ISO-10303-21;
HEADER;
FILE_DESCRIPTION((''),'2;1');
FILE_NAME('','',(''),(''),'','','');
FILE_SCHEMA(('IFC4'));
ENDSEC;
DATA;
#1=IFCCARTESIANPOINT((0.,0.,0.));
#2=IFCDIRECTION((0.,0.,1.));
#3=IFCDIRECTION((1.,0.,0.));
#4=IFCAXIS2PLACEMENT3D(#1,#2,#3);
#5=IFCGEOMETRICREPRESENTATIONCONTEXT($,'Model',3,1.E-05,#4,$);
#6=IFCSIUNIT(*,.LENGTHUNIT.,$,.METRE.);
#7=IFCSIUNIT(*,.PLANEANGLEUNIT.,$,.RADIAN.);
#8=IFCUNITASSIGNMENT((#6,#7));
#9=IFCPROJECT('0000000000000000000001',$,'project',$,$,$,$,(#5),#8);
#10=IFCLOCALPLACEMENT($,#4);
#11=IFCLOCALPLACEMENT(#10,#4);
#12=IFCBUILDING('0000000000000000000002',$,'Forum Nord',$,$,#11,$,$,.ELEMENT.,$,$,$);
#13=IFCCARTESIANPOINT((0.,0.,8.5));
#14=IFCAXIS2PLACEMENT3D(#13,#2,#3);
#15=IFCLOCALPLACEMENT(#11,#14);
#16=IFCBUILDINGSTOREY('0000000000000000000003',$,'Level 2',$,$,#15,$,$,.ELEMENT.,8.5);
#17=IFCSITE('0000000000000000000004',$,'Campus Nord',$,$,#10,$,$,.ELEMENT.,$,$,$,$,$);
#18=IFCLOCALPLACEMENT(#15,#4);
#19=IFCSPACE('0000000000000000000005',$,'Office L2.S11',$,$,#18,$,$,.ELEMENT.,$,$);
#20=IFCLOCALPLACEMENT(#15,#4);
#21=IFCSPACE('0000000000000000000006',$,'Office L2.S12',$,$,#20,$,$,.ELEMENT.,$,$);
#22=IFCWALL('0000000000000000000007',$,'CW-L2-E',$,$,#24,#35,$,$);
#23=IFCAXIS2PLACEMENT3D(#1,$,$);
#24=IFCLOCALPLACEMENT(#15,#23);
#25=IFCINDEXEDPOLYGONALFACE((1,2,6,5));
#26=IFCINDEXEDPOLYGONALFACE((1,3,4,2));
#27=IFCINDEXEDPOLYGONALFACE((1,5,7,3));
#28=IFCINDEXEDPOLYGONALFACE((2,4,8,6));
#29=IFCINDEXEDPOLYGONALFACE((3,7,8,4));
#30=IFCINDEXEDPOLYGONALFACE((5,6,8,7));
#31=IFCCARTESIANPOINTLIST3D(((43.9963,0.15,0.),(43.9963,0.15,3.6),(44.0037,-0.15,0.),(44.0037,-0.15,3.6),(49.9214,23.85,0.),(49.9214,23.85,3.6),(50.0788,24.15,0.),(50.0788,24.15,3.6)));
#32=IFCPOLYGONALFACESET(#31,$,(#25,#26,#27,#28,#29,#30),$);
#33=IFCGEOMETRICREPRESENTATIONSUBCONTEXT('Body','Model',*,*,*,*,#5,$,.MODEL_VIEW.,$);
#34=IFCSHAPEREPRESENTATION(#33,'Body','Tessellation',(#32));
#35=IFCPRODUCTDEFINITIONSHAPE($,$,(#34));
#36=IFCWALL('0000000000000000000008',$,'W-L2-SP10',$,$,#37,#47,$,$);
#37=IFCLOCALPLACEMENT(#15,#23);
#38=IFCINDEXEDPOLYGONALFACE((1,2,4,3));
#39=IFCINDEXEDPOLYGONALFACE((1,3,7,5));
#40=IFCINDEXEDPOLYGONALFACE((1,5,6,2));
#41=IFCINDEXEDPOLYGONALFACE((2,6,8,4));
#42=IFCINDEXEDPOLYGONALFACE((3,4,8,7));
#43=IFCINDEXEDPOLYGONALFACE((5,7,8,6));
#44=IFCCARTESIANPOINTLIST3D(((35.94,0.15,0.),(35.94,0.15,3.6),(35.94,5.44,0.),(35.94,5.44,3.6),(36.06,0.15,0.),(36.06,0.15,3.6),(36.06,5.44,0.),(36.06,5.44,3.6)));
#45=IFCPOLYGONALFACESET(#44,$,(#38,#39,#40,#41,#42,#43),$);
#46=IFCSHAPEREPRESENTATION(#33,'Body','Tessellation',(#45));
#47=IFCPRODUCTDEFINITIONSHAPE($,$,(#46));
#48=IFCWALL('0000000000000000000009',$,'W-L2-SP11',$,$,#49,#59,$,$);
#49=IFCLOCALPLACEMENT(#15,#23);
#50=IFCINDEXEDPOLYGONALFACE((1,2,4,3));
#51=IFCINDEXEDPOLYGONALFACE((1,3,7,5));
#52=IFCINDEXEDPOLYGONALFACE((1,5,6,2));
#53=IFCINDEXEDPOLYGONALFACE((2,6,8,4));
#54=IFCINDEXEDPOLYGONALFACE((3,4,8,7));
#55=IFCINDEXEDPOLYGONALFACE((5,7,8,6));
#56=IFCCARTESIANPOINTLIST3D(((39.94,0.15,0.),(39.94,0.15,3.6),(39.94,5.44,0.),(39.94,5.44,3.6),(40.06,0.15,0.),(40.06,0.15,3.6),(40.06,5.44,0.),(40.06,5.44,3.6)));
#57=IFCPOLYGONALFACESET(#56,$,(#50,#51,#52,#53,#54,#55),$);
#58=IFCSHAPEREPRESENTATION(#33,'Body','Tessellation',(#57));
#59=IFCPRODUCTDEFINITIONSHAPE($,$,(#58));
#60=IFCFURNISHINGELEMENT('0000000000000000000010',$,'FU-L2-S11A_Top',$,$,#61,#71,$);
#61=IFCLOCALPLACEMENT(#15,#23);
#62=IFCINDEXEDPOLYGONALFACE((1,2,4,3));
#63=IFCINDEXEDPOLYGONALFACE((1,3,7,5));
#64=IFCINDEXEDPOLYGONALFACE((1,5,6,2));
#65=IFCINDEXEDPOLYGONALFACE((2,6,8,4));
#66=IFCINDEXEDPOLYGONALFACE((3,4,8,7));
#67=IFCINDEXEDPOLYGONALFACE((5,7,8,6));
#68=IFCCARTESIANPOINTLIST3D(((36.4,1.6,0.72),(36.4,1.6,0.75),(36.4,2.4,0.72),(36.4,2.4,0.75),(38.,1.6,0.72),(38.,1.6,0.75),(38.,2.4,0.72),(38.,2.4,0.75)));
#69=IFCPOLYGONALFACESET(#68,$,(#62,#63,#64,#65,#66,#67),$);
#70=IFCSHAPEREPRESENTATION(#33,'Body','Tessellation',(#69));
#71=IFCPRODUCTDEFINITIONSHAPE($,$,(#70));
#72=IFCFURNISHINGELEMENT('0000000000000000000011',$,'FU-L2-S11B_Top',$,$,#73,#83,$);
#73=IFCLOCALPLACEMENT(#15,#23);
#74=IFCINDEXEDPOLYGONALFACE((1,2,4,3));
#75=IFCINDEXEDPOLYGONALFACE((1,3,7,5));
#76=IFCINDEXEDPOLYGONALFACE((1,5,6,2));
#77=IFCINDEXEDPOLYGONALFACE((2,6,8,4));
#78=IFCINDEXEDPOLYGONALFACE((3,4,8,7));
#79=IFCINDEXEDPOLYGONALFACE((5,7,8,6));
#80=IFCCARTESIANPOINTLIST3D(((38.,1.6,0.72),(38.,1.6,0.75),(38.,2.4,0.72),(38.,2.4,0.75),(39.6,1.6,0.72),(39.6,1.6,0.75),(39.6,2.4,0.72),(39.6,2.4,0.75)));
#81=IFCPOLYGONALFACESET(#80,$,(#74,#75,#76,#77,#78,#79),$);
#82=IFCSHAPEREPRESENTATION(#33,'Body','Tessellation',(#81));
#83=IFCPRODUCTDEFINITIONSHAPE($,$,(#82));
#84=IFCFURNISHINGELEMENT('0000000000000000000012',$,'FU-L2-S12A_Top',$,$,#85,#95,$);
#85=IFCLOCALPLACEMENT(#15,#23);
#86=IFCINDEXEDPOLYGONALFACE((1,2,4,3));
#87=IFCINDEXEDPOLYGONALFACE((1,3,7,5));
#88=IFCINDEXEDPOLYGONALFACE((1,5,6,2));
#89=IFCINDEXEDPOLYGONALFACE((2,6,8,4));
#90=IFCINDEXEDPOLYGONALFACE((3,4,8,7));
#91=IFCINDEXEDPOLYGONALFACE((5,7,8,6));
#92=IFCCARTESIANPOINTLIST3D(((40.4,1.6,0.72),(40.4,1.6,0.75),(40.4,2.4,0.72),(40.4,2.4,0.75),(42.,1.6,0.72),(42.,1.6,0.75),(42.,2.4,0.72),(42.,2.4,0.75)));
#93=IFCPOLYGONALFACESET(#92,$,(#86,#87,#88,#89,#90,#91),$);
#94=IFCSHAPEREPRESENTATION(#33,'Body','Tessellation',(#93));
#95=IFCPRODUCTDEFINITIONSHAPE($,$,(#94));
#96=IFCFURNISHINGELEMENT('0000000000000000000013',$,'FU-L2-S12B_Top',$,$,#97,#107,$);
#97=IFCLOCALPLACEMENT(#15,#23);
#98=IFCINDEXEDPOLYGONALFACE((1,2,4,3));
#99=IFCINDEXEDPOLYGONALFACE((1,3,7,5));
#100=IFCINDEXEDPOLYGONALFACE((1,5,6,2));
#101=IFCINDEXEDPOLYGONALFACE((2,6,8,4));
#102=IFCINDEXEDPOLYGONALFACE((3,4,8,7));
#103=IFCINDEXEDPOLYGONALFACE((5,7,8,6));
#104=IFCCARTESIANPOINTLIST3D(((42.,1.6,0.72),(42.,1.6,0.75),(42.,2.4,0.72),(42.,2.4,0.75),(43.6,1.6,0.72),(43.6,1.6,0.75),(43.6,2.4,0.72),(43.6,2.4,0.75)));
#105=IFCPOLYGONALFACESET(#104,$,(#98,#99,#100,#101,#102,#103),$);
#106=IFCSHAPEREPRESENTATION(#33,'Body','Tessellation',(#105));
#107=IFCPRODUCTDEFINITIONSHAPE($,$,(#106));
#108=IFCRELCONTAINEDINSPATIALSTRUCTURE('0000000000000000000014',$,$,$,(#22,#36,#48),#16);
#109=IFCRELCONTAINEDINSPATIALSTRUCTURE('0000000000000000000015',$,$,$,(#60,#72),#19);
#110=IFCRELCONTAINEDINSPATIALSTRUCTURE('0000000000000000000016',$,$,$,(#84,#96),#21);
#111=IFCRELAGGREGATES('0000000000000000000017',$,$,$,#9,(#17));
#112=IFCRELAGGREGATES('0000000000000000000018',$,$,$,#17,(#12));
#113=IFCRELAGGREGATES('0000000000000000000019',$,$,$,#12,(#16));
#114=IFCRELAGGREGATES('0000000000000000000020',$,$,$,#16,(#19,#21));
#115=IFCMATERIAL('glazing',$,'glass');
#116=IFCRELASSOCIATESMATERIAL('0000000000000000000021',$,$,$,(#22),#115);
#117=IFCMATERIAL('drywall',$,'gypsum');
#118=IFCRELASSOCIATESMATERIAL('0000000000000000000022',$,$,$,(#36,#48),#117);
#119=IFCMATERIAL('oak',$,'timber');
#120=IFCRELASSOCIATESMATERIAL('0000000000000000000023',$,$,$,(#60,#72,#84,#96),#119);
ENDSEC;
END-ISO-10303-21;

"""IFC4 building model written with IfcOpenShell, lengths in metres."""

from ifc_helpers import new_model, si_unit, frame, frame_2d, origin_with_axes, place, context, subcontext, project, spatial, polyline, rectangle, outline, extrude, material, element, save


model = new_model("IFC4")

# Units and contexts
model_context = context("Model", 3, precision=1e-05, world=origin_with_axes())
body_context = subcontext(model_context, "Body", "Model", "MODEL_VIEW")
ifc_project = project(units=[si_unit("LENGTHUNIT", "METRE"), si_unit("PLANEANGLEUNIT", "RADIAN")], contexts=[model_context])

# Site, building, storey
site_placement = place(None, origin_with_axes())
site = spatial("IfcSite", under=ifc_project, at=site_placement, Name="Campus Nord", CompositionType="ELEMENT")
building_placement = place(site_placement, origin_with_axes())
building = spatial("IfcBuilding", under=site, at=building_placement, Name="Forum Nord", CompositionType="ELEMENT")
storey_placement = place(building_placement, frame((0.0, 0.0, 8.5), z_axis=(0.0, 0.0, 1.0), x_axis=(1.0, 0.0, 0.0)))
storey = spatial("IfcBuildingStorey", under=building, at=storey_placement, Name="Level 2", CompositionType="ELEMENT", Elevation=8.5)

# Walls
ifc_material_1 = material(Name="glazing", Category="glass")
wall_placement = place(storey_placement, frame((44.0, 0.0, 0.0), z_axis=(0.0, 0.0, 1.0), x_axis=(0.24254, 0.97014, 0.0)))
element("IfcWall", 1, at=wall_placement, inside=storey, material=ifc_material_1, Name="CW-L2-E", context=body_context, shape_type="SweptSolid", body=[
    extrude(outline(polyline([(-0.1446, -0.04), (24.9032, -0.04), (24.574, 0.04), (0.1446, 0.04), (-0.1446, -0.04)])), origin_with_axes(), (0.0, 0.0, 1.0), 3.6),
])
ifc_material_2 = material(Name="drywall", Category="gypsum")
for number, where, z_axis, x_axis, name in (
    (2, (36.0, 0.0, 0.0), (0.0, 0.0, 1.0), (0.0, 1.0, 0.0), "W-L2-SP10"),
    (3, (40.0, 0.0, 0.0), (0.0, 0.0, 1.0), (0.0, 1.0, 0.0), "W-L2-SP11"),
):
    element("IfcWall", number, at=place(storey_placement, frame(where, z_axis=z_axis, x_axis=x_axis)), inside=storey, material=ifc_material_2, Name=name, context=body_context, shape_type="SweptSolid", body=[
        extrude(outline(polyline([(0.15, -0.06), (5.44, -0.06), (5.44, 0.06), (0.15, 0.06), (0.15, -0.06)])), origin_with_axes(), (0.0, 0.0, 1.0), 3.6),
    ])

# Shared definitions
space_1_placement = place(storey_placement, origin_with_axes())
space_1 = spatial("IfcSpace", under=storey, at=space_1_placement, Name="Office L2.S11", CompositionType="ELEMENT")

# Furnishing elements
ifc_material_3 = material(Name="oak", Category="timber")
furnishing_1_placement = place(storey_placement, frame((36.4, 1.0, 0.0), z_axis=(0.0, 0.0, 1.0), x_axis=(1.0, 0.0, 0.0)))
element("IfcFurnishingElement", 4, at=furnishing_1_placement, inside=space_1, material=ifc_material_3, Name="FU-L2-S11A_Top", context=body_context, shape_type="SweptSolid", body=[
    extrude(rectangle(XDim=1.6, YDim=0.8, at=frame_2d((0.8, 1.0), x_axis=(1.0, 0.0))), frame((0.0, 0.0, 0.72), z_axis=(0.0, 0.0, 1.0), x_axis=(1.0, 0.0, 0.0)), (0.0, 0.0, 1.0), 0.03),
])
furnishing_2_placement = place(storey_placement, frame((38.0, 1.0, 0.0), z_axis=(0.0, 0.0, 1.0), x_axis=(1.0, 0.0, 0.0)))
element("IfcFurnishingElement", 5, at=furnishing_2_placement, inside=space_1, material=ifc_material_3, Name="FU-L2-S11B_Top", context=body_context, shape_type="SweptSolid", body=[
    extrude(rectangle(XDim=1.6, YDim=0.8, at=frame_2d((0.8, 1.0), x_axis=(1.0, 0.0))), frame((0.0, 0.0, 0.72), z_axis=(0.0, 0.0, 1.0), x_axis=(1.0, 0.0, 0.0)), (0.0, 0.0, 1.0), 0.03),
])

# Shared definitions
space_2_placement = place(storey_placement, origin_with_axes())
space_2 = spatial("IfcSpace", under=storey, at=space_2_placement, Name="Office L2.S12", CompositionType="ELEMENT")

# Furnishing elements
furnishing_3_placement = place(storey_placement, frame((40.4, 1.0, 0.0), z_axis=(0.0, 0.0, 1.0), x_axis=(1.0, 0.0, 0.0)))
element("IfcFurnishingElement", 6, at=furnishing_3_placement, inside=space_2, material=ifc_material_3, Name="FU-L2-S12A_Top", context=body_context, shape_type="SweptSolid", body=[
    extrude(rectangle(XDim=1.6, YDim=0.8, at=frame_2d((0.8, 1.0), x_axis=(1.0, 0.0))), frame((0.0, 0.0, 0.72), z_axis=(0.0, 0.0, 1.0), x_axis=(1.0, 0.0, 0.0)), (0.0, 0.0, 1.0), 0.03),
])
furnishing_4_placement = place(storey_placement, frame((42.0, 1.0, 0.0), z_axis=(0.0, 0.0, 1.0), x_axis=(1.0, 0.0, 0.0)))
element("IfcFurnishingElement", 7, at=furnishing_4_placement, inside=space_2, material=ifc_material_3, Name="FU-L2-S12B_Top", context=body_context, shape_type="SweptSolid", body=[
    extrude(rectangle(XDim=1.6, YDim=0.8, at=frame_2d((0.8, 1.0), x_axis=(1.0, 0.0))), frame((0.0, 0.0, 0.72), z_axis=(0.0, 0.0, 1.0), x_axis=(1.0, 0.0, 0.0)), (0.0, 0.0, 1.0), 0.03),
])

save(model, "model.ifc")
